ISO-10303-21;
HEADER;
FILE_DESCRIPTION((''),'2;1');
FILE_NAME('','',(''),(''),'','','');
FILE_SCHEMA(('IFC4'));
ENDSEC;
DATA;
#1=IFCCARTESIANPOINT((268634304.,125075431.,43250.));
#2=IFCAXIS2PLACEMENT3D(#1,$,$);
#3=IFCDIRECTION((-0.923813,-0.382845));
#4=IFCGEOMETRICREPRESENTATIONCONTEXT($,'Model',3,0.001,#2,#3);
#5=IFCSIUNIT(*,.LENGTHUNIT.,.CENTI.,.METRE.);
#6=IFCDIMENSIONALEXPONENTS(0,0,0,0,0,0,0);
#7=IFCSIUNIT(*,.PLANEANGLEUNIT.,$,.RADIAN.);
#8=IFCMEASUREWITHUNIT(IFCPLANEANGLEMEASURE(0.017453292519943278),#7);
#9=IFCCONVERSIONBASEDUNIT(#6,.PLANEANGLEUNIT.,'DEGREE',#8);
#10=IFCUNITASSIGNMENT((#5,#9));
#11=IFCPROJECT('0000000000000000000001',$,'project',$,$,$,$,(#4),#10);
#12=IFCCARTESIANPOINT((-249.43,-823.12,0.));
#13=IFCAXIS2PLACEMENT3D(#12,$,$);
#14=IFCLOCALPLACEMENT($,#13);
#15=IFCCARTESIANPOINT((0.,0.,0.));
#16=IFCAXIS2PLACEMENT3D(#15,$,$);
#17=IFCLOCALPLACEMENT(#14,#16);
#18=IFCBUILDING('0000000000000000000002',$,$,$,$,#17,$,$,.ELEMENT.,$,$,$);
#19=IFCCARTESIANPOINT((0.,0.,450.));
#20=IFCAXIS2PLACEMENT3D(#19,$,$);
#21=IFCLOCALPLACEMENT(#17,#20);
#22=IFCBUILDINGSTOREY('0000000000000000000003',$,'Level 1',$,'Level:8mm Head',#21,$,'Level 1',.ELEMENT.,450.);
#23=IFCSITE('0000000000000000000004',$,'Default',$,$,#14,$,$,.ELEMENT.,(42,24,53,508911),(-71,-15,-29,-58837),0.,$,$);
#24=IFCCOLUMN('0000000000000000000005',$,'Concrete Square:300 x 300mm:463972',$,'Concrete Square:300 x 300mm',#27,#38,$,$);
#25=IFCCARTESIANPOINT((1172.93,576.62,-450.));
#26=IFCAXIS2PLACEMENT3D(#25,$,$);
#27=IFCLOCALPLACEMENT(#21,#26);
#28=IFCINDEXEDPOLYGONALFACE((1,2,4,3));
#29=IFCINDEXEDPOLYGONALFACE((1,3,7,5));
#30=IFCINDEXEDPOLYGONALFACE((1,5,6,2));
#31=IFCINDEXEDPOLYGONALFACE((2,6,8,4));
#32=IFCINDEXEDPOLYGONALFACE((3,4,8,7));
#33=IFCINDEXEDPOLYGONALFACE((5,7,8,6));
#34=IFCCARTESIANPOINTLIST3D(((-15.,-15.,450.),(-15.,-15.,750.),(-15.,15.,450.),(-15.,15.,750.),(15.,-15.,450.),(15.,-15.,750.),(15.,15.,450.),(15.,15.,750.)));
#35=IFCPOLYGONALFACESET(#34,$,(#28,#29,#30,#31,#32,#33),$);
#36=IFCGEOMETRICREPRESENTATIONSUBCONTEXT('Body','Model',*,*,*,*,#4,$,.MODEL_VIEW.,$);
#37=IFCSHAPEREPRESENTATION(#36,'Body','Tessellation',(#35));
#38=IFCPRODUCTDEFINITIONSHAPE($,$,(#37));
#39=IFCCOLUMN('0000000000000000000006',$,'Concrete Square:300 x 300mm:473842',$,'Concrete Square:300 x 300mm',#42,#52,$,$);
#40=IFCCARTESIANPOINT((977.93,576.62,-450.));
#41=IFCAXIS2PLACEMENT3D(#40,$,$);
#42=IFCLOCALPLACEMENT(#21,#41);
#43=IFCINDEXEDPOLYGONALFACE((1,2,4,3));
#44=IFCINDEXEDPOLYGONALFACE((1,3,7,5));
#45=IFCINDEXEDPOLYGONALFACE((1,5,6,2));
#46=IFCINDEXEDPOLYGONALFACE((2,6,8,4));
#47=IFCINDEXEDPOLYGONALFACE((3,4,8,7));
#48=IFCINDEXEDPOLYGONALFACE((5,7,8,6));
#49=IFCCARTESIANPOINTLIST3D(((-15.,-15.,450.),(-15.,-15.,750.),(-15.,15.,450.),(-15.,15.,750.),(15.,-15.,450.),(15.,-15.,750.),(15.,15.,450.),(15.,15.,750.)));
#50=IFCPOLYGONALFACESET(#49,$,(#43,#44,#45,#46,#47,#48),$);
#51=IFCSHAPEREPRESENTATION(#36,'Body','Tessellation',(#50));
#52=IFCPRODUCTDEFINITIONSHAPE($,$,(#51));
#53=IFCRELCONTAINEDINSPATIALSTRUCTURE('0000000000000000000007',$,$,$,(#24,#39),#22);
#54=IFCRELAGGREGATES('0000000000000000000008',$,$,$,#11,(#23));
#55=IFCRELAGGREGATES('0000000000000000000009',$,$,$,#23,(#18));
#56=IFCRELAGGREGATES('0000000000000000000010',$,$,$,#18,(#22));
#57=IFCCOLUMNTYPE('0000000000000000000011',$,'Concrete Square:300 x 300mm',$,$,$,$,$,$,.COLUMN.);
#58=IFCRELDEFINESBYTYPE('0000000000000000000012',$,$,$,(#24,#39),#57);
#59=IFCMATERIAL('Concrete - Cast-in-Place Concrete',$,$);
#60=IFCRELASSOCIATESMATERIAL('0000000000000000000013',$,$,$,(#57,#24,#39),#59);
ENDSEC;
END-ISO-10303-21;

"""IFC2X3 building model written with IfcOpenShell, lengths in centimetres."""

from ifc_helpers import new_model, entity, si_unit, converted_unit, direction, frame, origin, origin_2d_with_axis, place, context, subcontext, project, spatial, rectangle, extrude, source, transform, mapped, material, type_object, type_shapes, element, save


model = new_model("IFC2X3")

# Units and contexts
model_context = context("Model", 3, precision=0.001, world=frame((268634304.0, 125075431.0, 43250.0)), true_north=direction((-0.923813, -0.382845)))
body_context = subcontext(model_context, "Body", "Model", "MODEL_VIEW")
ifc_project = project(units=[si_unit("LENGTHUNIT", "METRE", prefix="CENTI"), converted_unit("PLANEANGLEUNIT", "DEGREE", entity("IfcPlaneAngleMeasure", 0.017453292519943278), si_unit("PLANEANGLEUNIT", "RADIAN"), dimensions=[0, 0, 0, 0, 0, 0, 0])], contexts=[model_context])

# Site, building, storey
site_placement = place(None, frame((-249.43, -823.12, 0.0)))
site = spatial("IfcSite", under=ifc_project, at=site_placement, Name="Default", CompositionType="ELEMENT", RefLatitude=(42, 24, 53, 508911), RefLongitude=(-71, -15, -29, -58837), RefElevation=0.0)
building_placement = place(site_placement, origin())
building = spatial("IfcBuilding", under=site, at=building_placement, CompositionType="ELEMENT")
storey_placement = place(building_placement, frame((0.0, 0.0, 450.0)))
storey = spatial("IfcBuildingStorey", under=building, at=storey_placement, Name="Level 1", ObjectType="Level:8mm Head", LongName="Level 1", CompositionType="ELEMENT", Elevation=450.0)

# Columns
ifc_material_1 = material(Name="Concrete - Cast-in-Place Concrete")
column_type_1 = type_object("IfcColumnType", Name="Concrete Square:300 x 300mm", PredefinedType="COLUMN", material=ifc_material_1)
shared_shape_1 = source(origin(), body_context, "Body", "SweptSolid", [
    extrude(rectangle(XDim=30.0, YDim=30.0, at=origin_2d_with_axis()), frame((0.0, 0.0, 450.0), z_axis=(0.0, 0.0, 1.0), x_axis=(-1.0, 0.0, 0.0)), (0.0, 0.0, 1.0), 300.0),
])
type_shapes(column_type_1, [shared_shape_1])
for number, where, name in (
    (1, (1172.93, 576.62, -450.0), "Concrete Square:300 x 300mm:463972"),
    (2, (977.93, 576.62, -450.0), "Concrete Square:300 x 300mm:473842"),
):
    element("IfcColumn", number, at=place(storey_placement, frame(where)), inside=storey, type_object=column_type_1, material=ifc_material_1, Name=name, ObjectType="Concrete Square:300 x 300mm", context=body_context, shape_type="MappedRepresentation", body=[
        mapped(shared_shape_1, transform((0.0, 0.0, 0.0), scale=1.0)),
    ])

save(model, "model.ifc")
